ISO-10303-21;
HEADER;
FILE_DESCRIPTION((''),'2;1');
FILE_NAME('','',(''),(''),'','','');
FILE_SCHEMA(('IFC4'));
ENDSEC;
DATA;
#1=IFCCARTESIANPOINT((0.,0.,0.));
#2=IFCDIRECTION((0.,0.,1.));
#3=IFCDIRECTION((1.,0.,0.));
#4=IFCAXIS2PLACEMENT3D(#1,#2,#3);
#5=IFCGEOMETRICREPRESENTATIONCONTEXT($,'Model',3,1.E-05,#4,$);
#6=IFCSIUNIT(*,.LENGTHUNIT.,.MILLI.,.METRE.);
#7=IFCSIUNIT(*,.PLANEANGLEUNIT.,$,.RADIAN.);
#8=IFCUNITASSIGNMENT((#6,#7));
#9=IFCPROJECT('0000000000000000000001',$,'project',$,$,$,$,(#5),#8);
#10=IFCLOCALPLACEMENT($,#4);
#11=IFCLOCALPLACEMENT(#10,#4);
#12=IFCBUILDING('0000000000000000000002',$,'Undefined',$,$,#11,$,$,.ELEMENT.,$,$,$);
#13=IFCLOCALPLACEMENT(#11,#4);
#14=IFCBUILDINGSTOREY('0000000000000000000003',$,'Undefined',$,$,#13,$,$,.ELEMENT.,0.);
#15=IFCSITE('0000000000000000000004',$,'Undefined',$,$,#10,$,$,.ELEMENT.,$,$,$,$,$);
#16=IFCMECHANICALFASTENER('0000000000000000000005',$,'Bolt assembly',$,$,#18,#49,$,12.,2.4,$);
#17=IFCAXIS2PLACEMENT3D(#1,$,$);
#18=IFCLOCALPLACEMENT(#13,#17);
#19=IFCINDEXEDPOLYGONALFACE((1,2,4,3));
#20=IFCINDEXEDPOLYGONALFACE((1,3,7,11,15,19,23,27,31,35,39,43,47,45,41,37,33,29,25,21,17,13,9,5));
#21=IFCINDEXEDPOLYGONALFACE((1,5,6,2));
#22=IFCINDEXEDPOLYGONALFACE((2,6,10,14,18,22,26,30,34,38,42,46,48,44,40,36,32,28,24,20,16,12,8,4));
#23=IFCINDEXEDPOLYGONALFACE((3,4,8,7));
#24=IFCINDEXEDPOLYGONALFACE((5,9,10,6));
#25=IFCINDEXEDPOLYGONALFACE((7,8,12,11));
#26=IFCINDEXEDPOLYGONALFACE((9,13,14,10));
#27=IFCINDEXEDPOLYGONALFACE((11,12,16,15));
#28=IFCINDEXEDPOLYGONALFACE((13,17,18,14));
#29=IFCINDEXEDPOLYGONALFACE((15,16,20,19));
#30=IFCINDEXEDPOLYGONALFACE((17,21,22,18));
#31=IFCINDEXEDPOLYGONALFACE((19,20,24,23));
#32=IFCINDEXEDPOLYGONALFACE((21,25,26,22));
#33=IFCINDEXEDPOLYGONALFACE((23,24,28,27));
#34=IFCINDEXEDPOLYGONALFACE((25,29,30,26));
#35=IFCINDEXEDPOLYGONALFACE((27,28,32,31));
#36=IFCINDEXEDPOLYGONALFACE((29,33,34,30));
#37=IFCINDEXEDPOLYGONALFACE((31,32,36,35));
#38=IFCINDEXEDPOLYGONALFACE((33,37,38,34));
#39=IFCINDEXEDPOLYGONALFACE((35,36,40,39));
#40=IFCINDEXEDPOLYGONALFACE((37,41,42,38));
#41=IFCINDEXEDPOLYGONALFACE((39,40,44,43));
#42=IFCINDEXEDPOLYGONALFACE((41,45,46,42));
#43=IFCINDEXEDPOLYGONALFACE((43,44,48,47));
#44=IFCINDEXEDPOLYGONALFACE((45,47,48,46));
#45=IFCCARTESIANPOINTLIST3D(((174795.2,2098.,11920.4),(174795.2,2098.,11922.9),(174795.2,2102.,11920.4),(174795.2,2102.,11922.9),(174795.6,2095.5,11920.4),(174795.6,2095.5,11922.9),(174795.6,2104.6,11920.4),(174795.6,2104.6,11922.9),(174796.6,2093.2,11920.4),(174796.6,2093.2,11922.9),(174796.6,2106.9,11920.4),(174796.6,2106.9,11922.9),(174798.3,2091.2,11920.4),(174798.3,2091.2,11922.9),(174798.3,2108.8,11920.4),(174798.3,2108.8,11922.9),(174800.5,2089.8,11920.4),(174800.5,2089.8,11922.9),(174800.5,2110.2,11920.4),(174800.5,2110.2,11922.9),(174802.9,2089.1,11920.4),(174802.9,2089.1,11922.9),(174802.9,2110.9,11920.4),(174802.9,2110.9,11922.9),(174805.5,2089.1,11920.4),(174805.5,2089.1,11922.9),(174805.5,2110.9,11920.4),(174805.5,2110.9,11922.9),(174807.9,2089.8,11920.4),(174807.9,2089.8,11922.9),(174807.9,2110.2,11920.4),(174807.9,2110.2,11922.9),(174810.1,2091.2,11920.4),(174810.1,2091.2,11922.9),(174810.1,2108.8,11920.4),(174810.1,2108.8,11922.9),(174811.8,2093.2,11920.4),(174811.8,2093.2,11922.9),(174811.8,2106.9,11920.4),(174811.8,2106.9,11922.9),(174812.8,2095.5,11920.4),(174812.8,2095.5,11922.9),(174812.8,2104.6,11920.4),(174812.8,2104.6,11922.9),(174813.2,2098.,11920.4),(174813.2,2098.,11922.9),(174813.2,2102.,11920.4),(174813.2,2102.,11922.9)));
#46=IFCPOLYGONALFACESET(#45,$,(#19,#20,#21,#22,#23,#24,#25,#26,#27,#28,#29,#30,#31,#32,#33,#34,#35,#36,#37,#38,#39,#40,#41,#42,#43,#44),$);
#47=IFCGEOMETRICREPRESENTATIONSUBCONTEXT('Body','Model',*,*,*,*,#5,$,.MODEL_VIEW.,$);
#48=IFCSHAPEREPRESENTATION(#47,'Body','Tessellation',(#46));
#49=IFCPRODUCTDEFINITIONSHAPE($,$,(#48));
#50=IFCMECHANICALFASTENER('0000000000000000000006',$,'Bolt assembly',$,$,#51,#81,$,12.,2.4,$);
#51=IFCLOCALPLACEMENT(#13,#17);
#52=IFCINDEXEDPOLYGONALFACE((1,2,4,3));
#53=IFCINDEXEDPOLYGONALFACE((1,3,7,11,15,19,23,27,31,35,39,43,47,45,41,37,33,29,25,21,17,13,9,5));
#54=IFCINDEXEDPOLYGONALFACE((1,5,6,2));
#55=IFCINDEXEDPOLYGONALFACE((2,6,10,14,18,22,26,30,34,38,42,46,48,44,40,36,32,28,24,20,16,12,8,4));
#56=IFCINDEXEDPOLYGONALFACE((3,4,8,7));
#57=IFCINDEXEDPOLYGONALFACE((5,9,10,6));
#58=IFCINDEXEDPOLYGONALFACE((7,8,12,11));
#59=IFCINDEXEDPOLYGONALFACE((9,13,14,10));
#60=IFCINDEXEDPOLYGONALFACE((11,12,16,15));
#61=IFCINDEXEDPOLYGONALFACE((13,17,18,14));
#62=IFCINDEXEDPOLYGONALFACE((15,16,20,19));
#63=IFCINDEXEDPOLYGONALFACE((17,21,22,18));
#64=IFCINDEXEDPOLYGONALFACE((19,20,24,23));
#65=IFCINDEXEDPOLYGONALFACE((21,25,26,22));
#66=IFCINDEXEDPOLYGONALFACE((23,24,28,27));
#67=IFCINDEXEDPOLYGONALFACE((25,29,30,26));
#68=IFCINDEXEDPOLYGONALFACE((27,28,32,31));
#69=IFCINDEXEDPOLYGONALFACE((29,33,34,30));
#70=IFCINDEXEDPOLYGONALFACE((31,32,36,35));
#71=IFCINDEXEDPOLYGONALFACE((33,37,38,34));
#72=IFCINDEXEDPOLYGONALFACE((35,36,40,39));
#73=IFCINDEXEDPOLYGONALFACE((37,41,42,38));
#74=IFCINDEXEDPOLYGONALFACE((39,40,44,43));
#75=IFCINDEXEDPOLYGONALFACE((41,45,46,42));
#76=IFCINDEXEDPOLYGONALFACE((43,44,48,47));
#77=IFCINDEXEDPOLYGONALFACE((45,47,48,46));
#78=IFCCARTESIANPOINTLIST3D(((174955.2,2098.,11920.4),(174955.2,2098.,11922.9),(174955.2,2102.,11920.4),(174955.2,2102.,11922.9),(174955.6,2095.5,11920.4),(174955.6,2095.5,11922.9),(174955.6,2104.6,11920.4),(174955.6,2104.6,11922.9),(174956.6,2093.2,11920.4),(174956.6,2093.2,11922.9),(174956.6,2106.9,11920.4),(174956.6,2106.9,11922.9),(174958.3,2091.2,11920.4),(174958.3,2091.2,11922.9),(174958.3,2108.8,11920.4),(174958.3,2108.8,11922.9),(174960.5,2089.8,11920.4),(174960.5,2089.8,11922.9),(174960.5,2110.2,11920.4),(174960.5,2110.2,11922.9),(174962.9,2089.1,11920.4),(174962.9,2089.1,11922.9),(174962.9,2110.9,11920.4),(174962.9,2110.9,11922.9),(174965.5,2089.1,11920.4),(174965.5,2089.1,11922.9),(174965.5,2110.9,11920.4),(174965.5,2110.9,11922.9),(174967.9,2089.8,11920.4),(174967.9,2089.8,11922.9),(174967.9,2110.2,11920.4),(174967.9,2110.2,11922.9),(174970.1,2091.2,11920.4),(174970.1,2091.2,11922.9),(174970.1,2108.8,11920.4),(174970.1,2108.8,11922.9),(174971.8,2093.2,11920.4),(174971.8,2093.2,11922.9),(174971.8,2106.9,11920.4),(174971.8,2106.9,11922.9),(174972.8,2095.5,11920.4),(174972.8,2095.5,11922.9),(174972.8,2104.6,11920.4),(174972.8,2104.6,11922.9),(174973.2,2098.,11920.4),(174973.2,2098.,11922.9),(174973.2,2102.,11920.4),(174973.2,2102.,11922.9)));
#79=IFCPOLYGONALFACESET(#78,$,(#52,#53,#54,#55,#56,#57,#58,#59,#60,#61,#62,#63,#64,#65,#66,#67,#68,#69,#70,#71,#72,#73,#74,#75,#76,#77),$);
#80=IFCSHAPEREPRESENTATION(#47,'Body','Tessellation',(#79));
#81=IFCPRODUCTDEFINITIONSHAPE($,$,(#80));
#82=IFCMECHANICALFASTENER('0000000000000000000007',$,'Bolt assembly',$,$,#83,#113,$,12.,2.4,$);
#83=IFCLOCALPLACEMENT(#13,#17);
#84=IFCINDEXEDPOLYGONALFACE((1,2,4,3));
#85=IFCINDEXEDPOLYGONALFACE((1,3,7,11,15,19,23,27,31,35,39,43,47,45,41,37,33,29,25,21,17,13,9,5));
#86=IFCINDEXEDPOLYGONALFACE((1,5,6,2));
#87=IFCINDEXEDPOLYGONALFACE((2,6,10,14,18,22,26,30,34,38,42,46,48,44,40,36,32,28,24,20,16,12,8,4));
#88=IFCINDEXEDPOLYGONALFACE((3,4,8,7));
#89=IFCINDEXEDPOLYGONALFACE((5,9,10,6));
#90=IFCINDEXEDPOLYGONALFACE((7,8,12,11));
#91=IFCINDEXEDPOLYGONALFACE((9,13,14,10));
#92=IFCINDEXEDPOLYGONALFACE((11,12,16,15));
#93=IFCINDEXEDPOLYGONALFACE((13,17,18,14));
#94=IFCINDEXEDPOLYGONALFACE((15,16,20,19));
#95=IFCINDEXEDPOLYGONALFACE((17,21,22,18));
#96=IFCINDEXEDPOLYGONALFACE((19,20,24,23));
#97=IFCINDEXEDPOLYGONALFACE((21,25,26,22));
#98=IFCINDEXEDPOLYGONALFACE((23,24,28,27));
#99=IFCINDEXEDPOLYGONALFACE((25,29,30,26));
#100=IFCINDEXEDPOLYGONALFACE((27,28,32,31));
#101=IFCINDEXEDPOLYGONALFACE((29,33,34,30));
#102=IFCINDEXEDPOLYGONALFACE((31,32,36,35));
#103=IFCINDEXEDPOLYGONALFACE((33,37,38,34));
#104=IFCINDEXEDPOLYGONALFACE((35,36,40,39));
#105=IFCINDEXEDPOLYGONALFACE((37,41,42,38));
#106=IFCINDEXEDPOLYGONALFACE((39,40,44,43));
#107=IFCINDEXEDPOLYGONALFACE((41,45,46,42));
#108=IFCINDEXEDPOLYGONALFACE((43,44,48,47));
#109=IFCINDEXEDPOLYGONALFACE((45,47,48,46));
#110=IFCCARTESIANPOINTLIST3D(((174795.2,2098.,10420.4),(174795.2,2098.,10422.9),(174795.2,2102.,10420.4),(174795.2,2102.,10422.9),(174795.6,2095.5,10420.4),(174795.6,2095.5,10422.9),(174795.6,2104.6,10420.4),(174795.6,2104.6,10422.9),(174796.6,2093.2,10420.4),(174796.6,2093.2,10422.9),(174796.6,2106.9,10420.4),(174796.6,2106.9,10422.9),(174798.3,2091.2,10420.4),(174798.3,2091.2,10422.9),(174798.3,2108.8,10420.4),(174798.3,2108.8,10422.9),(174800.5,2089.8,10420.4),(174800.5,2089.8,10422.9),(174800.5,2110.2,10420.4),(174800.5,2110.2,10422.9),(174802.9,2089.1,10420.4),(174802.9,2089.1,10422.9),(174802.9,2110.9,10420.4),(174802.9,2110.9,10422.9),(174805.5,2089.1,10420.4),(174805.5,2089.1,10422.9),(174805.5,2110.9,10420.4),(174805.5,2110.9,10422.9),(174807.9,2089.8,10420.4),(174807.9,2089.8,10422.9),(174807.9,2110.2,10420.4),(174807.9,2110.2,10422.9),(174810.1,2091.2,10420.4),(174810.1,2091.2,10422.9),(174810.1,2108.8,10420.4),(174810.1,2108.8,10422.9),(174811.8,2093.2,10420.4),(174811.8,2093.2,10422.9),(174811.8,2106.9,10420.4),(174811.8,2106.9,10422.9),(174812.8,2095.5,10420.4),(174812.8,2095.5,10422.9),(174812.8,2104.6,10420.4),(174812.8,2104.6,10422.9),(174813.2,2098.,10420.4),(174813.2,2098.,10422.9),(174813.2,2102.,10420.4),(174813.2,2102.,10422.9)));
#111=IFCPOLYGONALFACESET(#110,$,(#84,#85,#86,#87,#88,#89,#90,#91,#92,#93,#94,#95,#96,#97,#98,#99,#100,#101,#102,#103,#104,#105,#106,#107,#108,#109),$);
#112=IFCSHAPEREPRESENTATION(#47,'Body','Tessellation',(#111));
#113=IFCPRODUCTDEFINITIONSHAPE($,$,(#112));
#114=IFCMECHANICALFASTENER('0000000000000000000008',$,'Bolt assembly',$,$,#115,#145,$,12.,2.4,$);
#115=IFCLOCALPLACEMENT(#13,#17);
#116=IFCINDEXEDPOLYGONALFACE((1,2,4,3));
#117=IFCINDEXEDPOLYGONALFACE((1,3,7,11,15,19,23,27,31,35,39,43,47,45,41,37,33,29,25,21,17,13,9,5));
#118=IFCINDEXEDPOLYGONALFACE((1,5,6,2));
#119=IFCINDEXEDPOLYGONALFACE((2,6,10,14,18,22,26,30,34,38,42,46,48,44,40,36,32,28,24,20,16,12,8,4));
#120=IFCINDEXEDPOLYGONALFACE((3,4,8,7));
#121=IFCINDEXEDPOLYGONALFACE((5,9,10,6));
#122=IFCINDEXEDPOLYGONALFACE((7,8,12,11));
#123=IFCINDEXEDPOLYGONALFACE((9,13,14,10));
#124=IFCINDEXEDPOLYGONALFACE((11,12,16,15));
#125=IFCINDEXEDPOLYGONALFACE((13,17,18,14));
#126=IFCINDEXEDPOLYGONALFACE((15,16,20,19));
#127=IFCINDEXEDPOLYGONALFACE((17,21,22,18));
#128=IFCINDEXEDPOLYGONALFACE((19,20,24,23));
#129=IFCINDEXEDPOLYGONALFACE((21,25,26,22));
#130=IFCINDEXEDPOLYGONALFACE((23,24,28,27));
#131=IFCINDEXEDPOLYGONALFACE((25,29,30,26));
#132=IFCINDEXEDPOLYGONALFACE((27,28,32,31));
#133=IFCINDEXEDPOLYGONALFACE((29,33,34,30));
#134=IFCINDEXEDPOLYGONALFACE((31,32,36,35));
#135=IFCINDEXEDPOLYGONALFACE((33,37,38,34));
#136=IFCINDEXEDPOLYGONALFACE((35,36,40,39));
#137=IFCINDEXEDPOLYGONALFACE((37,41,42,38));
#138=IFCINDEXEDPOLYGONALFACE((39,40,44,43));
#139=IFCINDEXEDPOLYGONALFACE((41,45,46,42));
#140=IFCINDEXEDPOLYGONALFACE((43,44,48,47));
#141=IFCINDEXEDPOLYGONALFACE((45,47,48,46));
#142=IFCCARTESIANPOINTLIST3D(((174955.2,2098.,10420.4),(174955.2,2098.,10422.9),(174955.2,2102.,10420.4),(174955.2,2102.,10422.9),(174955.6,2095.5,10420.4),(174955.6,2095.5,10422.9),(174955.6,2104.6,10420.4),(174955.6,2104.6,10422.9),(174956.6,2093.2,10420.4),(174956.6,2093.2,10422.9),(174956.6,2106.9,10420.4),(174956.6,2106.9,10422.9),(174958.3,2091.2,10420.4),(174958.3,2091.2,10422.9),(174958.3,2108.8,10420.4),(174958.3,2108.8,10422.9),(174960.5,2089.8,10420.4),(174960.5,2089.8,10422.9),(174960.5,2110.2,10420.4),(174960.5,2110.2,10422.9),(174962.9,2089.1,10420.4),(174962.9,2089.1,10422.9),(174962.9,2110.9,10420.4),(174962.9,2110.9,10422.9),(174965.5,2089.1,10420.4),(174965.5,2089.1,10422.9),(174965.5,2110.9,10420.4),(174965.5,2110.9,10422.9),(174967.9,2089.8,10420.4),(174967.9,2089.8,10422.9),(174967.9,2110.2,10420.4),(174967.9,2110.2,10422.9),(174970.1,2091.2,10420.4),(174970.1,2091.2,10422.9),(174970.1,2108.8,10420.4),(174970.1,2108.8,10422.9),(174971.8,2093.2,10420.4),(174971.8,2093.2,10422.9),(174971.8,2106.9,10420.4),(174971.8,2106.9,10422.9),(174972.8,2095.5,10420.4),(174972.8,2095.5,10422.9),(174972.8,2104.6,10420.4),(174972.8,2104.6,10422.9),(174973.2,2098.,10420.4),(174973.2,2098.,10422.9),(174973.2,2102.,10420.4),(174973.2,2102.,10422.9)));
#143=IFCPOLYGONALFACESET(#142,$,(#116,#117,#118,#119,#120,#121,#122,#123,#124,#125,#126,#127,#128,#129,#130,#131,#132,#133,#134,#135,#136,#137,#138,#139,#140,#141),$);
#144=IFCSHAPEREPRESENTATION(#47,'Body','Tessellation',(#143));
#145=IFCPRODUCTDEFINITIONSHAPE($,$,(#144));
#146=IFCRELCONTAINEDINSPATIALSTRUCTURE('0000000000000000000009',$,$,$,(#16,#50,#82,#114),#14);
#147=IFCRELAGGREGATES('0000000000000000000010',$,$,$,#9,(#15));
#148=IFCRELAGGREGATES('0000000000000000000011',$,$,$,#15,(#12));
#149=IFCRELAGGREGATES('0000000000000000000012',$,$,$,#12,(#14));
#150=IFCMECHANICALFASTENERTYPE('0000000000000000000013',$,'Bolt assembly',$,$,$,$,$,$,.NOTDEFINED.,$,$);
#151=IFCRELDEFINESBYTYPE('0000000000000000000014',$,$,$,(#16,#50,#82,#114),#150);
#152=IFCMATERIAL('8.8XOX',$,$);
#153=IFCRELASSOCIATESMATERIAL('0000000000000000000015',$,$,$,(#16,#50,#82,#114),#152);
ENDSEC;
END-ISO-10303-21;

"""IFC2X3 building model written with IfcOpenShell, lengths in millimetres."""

from ifc_helpers import new_model, si_unit, frame, frame_2d, origin_with_axes, place, context, subcontext, project, spatial, polyline, circle_curve, parameter, trimmed, segment, composite_curve, outline, extrude, source, transform, mapped, material, type_object, element, save


model = new_model("IFC2X3")

# Units and contexts
model_context = context("Model", 3, precision=1e-05, world=origin_with_axes())
body_context = subcontext(model_context, "Body", "Model", "MODEL_VIEW")
ifc_project = project(units=[si_unit("LENGTHUNIT", "METRE", prefix="MILLI"), si_unit("PLANEANGLEUNIT", "RADIAN")], contexts=[model_context])

# Site, building, storey
site_placement = place(None, origin_with_axes())
site = spatial("IfcSite", under=ifc_project, at=site_placement, Name="Undefined", CompositionType="ELEMENT")
building_placement = place(site_placement, origin_with_axes())
building = spatial("IfcBuilding", under=site, at=building_placement, Name="Undefined", CompositionType="ELEMENT")
storey_placement = place(building_placement, origin_with_axes())
storey = spatial("IfcBuildingStorey", under=building, at=storey_placement, Name="Undefined", CompositionType="ELEMENT", Elevation=0.0)

# Mechanical fasteners
ifc_material_1 = material(Name="8.8XOX")
mechanical_fastener_type = type_object("IfcMechanicalFastenerType", Name="Bolt assembly")
shared_shape_1 = source(origin_with_axes(), body_context, "Body", "SweptSolid", [
    extrude(outline(composite_curve([segment(polyline([(9.0, 2.0), (9.0, -2.0)]), True, "CONTINUOUS"), segment(trimmed(circle_curve(frame_2d((0.0, -2.0), x_axis=(1.0, 0.0)), 9.0), [parameter(0.0)], [parameter(3.141593)], False, "PARAMETER"), True, "CONTINUOUS"), segment(polyline([(-9.0, -2.0), (-9.0, 2.0)]), True, "CONTINUOUS"), segment(trimmed(circle_curve(frame_2d((0.0, 2.0), x_axis=(-1.0, 0.0)), 9.0), [parameter(0.0)], [parameter(3.141593)], False, "PARAMETER"), True, "DISCONTINUOUS")], self_intersect=False)), frame((0.0, 2.3, 0.0), z_axis=(0.0, 1.0, 0.0), x_axis=(1.0, 0.0, 0.0)), (0.0, 0.0, 1.0), 2.5),
])
mechanical_fastener_1_placement = place(storey_placement, frame((174804.2, 2100.0, 11925.2), z_axis=(0.0, -1.0, 0.0), x_axis=(-1.0, 0.0, 0.0)))
element("IfcMechanicalFastener", 1, at=mechanical_fastener_1_placement, inside=storey, type_object=mechanical_fastener_type, material=ifc_material_1, Name="Bolt assembly", NominalDiameter=12.0, NominalLength=2.4, context=body_context, shape_type="MappedRepresentation", body=[
    mapped(shared_shape_1, transform((0.0, 0.0, 0.0))),
])
shared_shape_2 = source(origin_with_axes(), body_context, "Body", "SweptSolid", [
    extrude(outline(composite_curve([segment(polyline([(9.0, 2.0), (9.0, -2.0)]), True, "CONTINUOUS"), segment(trimmed(circle_curve(frame_2d((0.0, -2.0), x_axis=(1.0, 0.0)), 9.0), [parameter(0.0)], [parameter(3.141593)], False, "PARAMETER"), True, "CONTINUOUS"), segment(polyline([(-9.0, -2.0), (-9.0, 2.0)]), True, "CONTINUOUS"), segment(trimmed(circle_curve(frame_2d((0.0, 2.0), x_axis=(-1.0, 0.0)), 9.0), [parameter(0.0)], [parameter(3.141593)], False, "PARAMETER"), True, "DISCONTINUOUS")], self_intersect=False)), frame((0.0, 2.3, 0.0), z_axis=(0.0, 1.0, 0.0), x_axis=(1.0, 0.0, 0.0)), (0.0, 0.0, 1.0), 2.5),
])
mechanical_fastener_2_placement = place(storey_placement, frame((174964.2, 2100.0, 11925.2), z_axis=(0.0, -1.0, 0.0), x_axis=(-1.0, 0.0, 0.0)))
element("IfcMechanicalFastener", 2, at=mechanical_fastener_2_placement, inside=storey, type_object=mechanical_fastener_type, material=ifc_material_1, Name="Bolt assembly", NominalDiameter=12.0, NominalLength=2.4, context=body_context, shape_type="MappedRepresentation", body=[
    mapped(shared_shape_2, transform((0.0, 0.0, 0.0))),
])
shared_shape_3 = source(origin_with_axes(), body_context, "Body", "SweptSolid", [
    extrude(outline(composite_curve([segment(polyline([(9.0, 2.0), (9.0, -2.0)]), True, "CONTINUOUS"), segment(trimmed(circle_curve(frame_2d((0.0, -2.0), x_axis=(1.0, 0.0)), 9.0), [parameter(0.0)], [parameter(3.141593)], False, "PARAMETER"), True, "CONTINUOUS"), segment(polyline([(-9.0, -2.0), (-9.0, 2.0)]), True, "CONTINUOUS"), segment(trimmed(circle_curve(frame_2d((0.0, 2.0), x_axis=(-1.0, 0.0)), 9.0), [parameter(0.0)], [parameter(3.141593)], False, "PARAMETER"), True, "DISCONTINUOUS")], self_intersect=False)), frame((0.0, 2.3, 0.0), z_axis=(0.0, 1.0, 0.0), x_axis=(1.0, 0.0, 0.0)), (0.0, 0.0, 1.0), 2.5),
])
mechanical_fastener_3_placement = place(storey_placement, frame((174804.2, 2100.0, 10425.2), z_axis=(0.0, -1.0, 0.0), x_axis=(-1.0, 0.0, 0.0)))
element("IfcMechanicalFastener", 3, at=mechanical_fastener_3_placement, inside=storey, type_object=mechanical_fastener_type, material=ifc_material_1, Name="Bolt assembly", NominalDiameter=12.0, NominalLength=2.4, context=body_context, shape_type="MappedRepresentation", body=[
    mapped(shared_shape_3, transform((0.0, 0.0, 0.0))),
])
shared_shape_4 = source(origin_with_axes(), body_context, "Body", "SweptSolid", [
    extrude(outline(composite_curve([segment(polyline([(9.0, 2.0), (9.0, -2.0)]), True, "CONTINUOUS"), segment(trimmed(circle_curve(frame_2d((0.0, -2.0), x_axis=(1.0, 0.0)), 9.0), [parameter(0.0)], [parameter(3.141593)], False, "PARAMETER"), True, "CONTINUOUS"), segment(polyline([(-9.0, -2.0), (-9.0, 2.0)]), True, "CONTINUOUS"), segment(trimmed(circle_curve(frame_2d((0.0, 2.0), x_axis=(-1.0, 0.0)), 9.0), [parameter(0.0)], [parameter(3.141593)], False, "PARAMETER"), True, "DISCONTINUOUS")], self_intersect=False)), frame((0.0, 2.3, 0.0), z_axis=(0.0, 1.0, 0.0), x_axis=(1.0, 0.0, 0.0)), (0.0, 0.0, 1.0), 2.5),
])
mechanical_fastener_4_placement = place(storey_placement, frame((174964.2, 2100.0, 10425.2), z_axis=(0.0, -1.0, 0.0), x_axis=(-1.0, 0.0, 0.0)))
element("IfcMechanicalFastener", 4, at=mechanical_fastener_4_placement, inside=storey, type_object=mechanical_fastener_type, material=ifc_material_1, Name="Bolt assembly", NominalDiameter=12.0, NominalLength=2.4, context=body_context, shape_type="MappedRepresentation", body=[
    mapped(shared_shape_4, transform((0.0, 0.0, 0.0))),
])

save(model, "model.ifc")
